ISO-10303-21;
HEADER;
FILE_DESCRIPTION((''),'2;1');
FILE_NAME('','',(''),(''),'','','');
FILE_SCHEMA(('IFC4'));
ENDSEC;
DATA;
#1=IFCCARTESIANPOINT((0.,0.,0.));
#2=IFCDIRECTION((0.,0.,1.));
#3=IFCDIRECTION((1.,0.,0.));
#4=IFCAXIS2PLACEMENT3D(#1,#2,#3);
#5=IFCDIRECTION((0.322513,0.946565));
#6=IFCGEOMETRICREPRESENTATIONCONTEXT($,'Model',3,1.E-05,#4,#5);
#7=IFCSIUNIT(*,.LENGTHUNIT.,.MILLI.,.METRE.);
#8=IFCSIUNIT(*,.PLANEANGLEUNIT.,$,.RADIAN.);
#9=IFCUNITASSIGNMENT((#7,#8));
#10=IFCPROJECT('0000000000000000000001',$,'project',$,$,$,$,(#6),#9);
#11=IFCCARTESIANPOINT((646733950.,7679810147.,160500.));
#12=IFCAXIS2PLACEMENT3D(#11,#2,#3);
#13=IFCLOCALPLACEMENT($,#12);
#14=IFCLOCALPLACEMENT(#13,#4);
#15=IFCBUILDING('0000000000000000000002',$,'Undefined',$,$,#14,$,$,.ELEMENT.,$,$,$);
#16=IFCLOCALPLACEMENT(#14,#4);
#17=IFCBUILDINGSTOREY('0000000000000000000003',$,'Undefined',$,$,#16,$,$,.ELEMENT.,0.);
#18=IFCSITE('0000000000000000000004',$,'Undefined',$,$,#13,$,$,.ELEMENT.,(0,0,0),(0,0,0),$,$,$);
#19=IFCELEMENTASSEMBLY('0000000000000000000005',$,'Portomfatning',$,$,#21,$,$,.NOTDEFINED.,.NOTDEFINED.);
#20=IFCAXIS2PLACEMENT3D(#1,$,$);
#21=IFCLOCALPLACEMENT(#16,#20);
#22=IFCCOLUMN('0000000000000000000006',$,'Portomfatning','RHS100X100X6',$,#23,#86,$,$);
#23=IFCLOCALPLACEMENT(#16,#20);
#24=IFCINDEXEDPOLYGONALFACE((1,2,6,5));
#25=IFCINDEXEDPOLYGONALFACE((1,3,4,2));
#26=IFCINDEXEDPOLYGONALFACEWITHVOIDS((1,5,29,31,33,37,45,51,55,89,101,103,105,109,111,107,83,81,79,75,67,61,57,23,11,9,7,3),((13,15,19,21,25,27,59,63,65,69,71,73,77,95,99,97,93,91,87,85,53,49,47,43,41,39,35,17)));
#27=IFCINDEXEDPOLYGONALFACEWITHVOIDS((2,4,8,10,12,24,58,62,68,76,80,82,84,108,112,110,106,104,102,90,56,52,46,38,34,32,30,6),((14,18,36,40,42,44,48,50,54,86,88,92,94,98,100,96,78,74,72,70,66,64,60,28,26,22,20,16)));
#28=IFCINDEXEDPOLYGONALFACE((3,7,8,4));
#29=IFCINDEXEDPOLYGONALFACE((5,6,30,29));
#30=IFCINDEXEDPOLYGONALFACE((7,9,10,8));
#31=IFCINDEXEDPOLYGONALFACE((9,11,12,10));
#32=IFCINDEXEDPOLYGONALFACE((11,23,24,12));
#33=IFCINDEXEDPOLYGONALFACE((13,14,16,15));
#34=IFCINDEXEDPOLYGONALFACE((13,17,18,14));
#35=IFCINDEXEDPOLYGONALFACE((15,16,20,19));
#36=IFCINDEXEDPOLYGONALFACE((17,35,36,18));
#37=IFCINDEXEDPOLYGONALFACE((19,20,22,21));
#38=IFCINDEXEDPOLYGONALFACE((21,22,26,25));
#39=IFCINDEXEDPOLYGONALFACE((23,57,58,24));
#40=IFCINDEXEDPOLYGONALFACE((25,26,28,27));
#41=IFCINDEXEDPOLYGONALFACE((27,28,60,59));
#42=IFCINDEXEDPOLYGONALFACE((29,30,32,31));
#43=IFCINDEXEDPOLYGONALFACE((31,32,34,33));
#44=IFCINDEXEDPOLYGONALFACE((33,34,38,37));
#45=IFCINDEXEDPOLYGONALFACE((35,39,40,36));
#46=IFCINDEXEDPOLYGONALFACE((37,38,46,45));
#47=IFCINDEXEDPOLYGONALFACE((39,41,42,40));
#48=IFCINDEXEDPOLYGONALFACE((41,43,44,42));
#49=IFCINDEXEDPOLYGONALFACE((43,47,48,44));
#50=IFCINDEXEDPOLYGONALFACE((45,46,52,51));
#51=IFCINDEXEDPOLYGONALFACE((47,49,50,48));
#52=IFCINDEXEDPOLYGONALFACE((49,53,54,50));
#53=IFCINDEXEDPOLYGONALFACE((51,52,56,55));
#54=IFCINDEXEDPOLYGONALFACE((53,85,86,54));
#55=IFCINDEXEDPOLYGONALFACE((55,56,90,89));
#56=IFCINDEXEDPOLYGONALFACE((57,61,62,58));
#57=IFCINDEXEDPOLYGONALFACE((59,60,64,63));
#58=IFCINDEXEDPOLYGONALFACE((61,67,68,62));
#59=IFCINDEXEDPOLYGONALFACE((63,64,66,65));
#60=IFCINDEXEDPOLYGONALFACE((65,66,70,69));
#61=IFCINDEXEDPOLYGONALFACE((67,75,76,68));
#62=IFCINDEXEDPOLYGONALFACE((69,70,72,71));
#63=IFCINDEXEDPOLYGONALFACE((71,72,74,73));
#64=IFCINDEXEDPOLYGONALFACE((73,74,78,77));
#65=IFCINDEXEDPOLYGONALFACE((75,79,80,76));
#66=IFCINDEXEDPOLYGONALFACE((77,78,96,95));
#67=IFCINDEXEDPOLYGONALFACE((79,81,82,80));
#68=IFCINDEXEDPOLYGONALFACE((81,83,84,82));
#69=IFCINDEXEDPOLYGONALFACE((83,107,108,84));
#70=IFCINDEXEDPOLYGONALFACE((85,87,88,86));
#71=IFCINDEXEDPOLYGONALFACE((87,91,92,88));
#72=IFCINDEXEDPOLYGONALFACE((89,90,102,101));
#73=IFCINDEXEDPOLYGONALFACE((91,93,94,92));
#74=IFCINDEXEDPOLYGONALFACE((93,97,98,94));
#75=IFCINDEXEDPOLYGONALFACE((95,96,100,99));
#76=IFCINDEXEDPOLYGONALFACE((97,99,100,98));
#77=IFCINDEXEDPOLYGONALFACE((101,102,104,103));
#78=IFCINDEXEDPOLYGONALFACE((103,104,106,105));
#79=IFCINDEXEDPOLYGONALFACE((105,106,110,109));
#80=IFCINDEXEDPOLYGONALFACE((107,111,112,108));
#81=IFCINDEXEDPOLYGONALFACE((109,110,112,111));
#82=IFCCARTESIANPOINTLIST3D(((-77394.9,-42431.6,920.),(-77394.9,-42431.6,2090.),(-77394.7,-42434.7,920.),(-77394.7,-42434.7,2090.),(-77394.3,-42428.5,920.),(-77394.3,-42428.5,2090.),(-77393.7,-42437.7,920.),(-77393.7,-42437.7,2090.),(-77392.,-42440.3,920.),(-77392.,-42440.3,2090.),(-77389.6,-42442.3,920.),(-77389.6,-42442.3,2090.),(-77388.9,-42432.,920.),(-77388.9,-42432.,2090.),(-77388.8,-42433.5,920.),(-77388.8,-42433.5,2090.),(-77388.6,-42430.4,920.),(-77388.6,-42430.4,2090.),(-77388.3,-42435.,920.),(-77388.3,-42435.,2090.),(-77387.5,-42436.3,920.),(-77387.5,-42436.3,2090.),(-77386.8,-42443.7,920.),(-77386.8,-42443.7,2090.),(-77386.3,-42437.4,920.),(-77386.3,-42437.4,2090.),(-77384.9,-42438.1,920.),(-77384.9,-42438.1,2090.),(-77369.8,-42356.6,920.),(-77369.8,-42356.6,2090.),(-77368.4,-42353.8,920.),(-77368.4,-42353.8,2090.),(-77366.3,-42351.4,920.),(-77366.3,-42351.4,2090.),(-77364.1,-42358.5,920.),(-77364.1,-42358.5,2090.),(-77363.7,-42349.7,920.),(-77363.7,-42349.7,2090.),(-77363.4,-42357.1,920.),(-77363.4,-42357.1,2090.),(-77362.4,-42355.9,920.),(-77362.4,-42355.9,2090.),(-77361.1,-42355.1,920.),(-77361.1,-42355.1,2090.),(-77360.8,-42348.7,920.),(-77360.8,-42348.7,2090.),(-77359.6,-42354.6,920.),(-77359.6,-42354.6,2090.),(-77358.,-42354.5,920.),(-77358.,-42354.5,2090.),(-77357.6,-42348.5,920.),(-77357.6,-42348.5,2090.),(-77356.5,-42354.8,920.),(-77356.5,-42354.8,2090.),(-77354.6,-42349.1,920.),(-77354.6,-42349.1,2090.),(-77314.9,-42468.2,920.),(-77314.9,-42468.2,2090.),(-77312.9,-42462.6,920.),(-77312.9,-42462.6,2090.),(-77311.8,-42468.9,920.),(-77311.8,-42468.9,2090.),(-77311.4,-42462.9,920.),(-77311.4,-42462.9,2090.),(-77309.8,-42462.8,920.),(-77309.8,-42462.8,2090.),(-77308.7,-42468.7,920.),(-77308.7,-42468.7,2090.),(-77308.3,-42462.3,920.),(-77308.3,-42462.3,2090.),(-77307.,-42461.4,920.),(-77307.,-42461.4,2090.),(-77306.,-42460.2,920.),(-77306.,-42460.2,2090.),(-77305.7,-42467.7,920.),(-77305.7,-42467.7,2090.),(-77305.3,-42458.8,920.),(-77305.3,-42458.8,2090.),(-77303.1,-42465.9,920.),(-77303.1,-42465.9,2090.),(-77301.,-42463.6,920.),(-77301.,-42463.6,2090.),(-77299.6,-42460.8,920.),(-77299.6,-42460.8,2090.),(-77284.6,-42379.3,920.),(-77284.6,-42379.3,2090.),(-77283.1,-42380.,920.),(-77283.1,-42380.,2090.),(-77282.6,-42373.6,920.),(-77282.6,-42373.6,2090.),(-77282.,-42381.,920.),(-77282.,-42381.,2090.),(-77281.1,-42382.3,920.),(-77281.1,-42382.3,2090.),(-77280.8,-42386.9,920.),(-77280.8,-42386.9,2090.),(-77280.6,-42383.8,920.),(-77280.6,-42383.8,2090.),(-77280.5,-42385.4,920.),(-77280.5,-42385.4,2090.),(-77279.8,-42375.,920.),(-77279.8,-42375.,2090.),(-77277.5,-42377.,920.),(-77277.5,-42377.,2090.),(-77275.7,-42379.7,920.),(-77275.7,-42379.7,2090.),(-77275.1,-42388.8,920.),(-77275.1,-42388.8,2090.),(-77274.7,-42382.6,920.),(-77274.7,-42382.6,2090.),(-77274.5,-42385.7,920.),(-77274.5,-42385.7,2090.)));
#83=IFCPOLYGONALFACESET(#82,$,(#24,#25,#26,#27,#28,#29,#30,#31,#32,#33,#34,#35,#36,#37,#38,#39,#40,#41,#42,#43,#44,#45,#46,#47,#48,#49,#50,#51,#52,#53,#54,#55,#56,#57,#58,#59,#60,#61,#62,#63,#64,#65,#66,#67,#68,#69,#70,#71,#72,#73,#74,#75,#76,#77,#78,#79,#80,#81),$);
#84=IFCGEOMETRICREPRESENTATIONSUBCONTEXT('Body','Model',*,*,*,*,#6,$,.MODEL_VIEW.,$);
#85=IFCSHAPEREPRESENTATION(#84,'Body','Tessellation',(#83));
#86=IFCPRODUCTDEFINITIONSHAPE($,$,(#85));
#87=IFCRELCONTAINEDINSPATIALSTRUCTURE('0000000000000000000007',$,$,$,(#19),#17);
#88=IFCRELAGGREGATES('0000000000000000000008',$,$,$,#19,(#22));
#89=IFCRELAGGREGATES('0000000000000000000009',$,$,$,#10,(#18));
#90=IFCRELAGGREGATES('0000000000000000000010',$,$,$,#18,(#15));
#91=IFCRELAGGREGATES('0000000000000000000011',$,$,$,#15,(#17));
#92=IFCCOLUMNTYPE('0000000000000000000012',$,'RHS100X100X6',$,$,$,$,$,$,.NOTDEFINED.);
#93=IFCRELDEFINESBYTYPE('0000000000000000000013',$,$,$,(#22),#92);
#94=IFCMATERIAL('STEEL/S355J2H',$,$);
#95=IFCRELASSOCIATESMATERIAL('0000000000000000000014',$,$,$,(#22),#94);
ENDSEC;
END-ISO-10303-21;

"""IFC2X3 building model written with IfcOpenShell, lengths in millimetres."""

from ifc_helpers import new_model, si_unit, direction, frame, origin_with_axes, origin_2d_with_axis, place, context, subcontext, project, spatial, hollow_rectangle, extrude, clip, halfspace, material, type_object, element, aggregate, save


model = new_model("IFC2X3")

# Units and contexts
model_context = context("Model", 3, precision=1e-05, world=origin_with_axes(), true_north=direction((0.322513, 0.946565)))
body_context = subcontext(model_context, "Body", "Model", "MODEL_VIEW")
ifc_project = project(units=[si_unit("LENGTHUNIT", "METRE", prefix="MILLI"), si_unit("PLANEANGLEUNIT", "RADIAN")], contexts=[model_context])

# Site, building, storey
site_placement = place(None, frame((646733950.0, 7679810147.0, 160500.0), z_axis=(0.0, 0.0, 1.0), x_axis=(1.0, 0.0, 0.0)))
site = spatial("IfcSite", under=ifc_project, at=site_placement, Name="Undefined", CompositionType="ELEMENT", RefLatitude=(0, 0, 0), RefLongitude=(0, 0, 0))
building_placement = place(site_placement, origin_with_axes())
building = spatial("IfcBuilding", under=site, at=building_placement, Name="Undefined", CompositionType="ELEMENT")
storey_placement = place(building_placement, origin_with_axes())
storey = spatial("IfcBuildingStorey", under=building, at=storey_placement, Name="Undefined", CompositionType="ELEMENT", Elevation=0.0)

# Element assembly, column
assembly_1_placement = place(storey_placement, origin_with_axes())
assembly_1 = element("IfcElementAssembly", 1, at=assembly_1_placement, inside=storey, Name="Portomfatning", AssemblyPlace="NOTDEFINED", PredefinedType="NOTDEFINED")
ifc_material_1 = material(Name="STEEL/S355J2H")
column_type_1 = type_object("IfcColumnType", Name="RHS100X100X6", PredefinedType="NOTDEFINED")
column_1_placement = place(assembly_1_placement, frame((-77334.7, -42408.7, 910.0), z_axis=(0.0, 0.0, 1.0), x_axis=(-0.946565, 0.322513, 0.0)))
column_1 = element("IfcColumn", 2, at=column_1_placement, type_object=column_type_1, material=ifc_material_1, Name="Portomfatning", Description="RHS100X100X6", context=body_context, shape_type="Clipping", body=[
    clip(clip(extrude(hollow_rectangle(XDim=100.0, YDim=100.0, WallThickness=6.0, InnerFilletRadius=6.0, OuterFilletRadius=12.0, at=origin_2d_with_axis()), frame((0.0, 0.0, 1190.0), z_axis=(0.0, 0.0, -1.0), x_axis=(0.0, 1.0, 0.0)), (0.0, 0.0, 1.0), 1190.0), halfspace(frame((-50.0, 0.0, 1180.0), z_axis=(0.0, 0.0, -1.0), x_axis=(0.0, -1.0, 0.0)), True)), halfspace(frame((-50.0, 0.0, 10.0), z_axis=(0.0, 0.0, 1.0), x_axis=(0.0, 1.0, 0.0)), True)),
])

aggregate(assembly_1, [column_1])

save(model, "model.ifc")
